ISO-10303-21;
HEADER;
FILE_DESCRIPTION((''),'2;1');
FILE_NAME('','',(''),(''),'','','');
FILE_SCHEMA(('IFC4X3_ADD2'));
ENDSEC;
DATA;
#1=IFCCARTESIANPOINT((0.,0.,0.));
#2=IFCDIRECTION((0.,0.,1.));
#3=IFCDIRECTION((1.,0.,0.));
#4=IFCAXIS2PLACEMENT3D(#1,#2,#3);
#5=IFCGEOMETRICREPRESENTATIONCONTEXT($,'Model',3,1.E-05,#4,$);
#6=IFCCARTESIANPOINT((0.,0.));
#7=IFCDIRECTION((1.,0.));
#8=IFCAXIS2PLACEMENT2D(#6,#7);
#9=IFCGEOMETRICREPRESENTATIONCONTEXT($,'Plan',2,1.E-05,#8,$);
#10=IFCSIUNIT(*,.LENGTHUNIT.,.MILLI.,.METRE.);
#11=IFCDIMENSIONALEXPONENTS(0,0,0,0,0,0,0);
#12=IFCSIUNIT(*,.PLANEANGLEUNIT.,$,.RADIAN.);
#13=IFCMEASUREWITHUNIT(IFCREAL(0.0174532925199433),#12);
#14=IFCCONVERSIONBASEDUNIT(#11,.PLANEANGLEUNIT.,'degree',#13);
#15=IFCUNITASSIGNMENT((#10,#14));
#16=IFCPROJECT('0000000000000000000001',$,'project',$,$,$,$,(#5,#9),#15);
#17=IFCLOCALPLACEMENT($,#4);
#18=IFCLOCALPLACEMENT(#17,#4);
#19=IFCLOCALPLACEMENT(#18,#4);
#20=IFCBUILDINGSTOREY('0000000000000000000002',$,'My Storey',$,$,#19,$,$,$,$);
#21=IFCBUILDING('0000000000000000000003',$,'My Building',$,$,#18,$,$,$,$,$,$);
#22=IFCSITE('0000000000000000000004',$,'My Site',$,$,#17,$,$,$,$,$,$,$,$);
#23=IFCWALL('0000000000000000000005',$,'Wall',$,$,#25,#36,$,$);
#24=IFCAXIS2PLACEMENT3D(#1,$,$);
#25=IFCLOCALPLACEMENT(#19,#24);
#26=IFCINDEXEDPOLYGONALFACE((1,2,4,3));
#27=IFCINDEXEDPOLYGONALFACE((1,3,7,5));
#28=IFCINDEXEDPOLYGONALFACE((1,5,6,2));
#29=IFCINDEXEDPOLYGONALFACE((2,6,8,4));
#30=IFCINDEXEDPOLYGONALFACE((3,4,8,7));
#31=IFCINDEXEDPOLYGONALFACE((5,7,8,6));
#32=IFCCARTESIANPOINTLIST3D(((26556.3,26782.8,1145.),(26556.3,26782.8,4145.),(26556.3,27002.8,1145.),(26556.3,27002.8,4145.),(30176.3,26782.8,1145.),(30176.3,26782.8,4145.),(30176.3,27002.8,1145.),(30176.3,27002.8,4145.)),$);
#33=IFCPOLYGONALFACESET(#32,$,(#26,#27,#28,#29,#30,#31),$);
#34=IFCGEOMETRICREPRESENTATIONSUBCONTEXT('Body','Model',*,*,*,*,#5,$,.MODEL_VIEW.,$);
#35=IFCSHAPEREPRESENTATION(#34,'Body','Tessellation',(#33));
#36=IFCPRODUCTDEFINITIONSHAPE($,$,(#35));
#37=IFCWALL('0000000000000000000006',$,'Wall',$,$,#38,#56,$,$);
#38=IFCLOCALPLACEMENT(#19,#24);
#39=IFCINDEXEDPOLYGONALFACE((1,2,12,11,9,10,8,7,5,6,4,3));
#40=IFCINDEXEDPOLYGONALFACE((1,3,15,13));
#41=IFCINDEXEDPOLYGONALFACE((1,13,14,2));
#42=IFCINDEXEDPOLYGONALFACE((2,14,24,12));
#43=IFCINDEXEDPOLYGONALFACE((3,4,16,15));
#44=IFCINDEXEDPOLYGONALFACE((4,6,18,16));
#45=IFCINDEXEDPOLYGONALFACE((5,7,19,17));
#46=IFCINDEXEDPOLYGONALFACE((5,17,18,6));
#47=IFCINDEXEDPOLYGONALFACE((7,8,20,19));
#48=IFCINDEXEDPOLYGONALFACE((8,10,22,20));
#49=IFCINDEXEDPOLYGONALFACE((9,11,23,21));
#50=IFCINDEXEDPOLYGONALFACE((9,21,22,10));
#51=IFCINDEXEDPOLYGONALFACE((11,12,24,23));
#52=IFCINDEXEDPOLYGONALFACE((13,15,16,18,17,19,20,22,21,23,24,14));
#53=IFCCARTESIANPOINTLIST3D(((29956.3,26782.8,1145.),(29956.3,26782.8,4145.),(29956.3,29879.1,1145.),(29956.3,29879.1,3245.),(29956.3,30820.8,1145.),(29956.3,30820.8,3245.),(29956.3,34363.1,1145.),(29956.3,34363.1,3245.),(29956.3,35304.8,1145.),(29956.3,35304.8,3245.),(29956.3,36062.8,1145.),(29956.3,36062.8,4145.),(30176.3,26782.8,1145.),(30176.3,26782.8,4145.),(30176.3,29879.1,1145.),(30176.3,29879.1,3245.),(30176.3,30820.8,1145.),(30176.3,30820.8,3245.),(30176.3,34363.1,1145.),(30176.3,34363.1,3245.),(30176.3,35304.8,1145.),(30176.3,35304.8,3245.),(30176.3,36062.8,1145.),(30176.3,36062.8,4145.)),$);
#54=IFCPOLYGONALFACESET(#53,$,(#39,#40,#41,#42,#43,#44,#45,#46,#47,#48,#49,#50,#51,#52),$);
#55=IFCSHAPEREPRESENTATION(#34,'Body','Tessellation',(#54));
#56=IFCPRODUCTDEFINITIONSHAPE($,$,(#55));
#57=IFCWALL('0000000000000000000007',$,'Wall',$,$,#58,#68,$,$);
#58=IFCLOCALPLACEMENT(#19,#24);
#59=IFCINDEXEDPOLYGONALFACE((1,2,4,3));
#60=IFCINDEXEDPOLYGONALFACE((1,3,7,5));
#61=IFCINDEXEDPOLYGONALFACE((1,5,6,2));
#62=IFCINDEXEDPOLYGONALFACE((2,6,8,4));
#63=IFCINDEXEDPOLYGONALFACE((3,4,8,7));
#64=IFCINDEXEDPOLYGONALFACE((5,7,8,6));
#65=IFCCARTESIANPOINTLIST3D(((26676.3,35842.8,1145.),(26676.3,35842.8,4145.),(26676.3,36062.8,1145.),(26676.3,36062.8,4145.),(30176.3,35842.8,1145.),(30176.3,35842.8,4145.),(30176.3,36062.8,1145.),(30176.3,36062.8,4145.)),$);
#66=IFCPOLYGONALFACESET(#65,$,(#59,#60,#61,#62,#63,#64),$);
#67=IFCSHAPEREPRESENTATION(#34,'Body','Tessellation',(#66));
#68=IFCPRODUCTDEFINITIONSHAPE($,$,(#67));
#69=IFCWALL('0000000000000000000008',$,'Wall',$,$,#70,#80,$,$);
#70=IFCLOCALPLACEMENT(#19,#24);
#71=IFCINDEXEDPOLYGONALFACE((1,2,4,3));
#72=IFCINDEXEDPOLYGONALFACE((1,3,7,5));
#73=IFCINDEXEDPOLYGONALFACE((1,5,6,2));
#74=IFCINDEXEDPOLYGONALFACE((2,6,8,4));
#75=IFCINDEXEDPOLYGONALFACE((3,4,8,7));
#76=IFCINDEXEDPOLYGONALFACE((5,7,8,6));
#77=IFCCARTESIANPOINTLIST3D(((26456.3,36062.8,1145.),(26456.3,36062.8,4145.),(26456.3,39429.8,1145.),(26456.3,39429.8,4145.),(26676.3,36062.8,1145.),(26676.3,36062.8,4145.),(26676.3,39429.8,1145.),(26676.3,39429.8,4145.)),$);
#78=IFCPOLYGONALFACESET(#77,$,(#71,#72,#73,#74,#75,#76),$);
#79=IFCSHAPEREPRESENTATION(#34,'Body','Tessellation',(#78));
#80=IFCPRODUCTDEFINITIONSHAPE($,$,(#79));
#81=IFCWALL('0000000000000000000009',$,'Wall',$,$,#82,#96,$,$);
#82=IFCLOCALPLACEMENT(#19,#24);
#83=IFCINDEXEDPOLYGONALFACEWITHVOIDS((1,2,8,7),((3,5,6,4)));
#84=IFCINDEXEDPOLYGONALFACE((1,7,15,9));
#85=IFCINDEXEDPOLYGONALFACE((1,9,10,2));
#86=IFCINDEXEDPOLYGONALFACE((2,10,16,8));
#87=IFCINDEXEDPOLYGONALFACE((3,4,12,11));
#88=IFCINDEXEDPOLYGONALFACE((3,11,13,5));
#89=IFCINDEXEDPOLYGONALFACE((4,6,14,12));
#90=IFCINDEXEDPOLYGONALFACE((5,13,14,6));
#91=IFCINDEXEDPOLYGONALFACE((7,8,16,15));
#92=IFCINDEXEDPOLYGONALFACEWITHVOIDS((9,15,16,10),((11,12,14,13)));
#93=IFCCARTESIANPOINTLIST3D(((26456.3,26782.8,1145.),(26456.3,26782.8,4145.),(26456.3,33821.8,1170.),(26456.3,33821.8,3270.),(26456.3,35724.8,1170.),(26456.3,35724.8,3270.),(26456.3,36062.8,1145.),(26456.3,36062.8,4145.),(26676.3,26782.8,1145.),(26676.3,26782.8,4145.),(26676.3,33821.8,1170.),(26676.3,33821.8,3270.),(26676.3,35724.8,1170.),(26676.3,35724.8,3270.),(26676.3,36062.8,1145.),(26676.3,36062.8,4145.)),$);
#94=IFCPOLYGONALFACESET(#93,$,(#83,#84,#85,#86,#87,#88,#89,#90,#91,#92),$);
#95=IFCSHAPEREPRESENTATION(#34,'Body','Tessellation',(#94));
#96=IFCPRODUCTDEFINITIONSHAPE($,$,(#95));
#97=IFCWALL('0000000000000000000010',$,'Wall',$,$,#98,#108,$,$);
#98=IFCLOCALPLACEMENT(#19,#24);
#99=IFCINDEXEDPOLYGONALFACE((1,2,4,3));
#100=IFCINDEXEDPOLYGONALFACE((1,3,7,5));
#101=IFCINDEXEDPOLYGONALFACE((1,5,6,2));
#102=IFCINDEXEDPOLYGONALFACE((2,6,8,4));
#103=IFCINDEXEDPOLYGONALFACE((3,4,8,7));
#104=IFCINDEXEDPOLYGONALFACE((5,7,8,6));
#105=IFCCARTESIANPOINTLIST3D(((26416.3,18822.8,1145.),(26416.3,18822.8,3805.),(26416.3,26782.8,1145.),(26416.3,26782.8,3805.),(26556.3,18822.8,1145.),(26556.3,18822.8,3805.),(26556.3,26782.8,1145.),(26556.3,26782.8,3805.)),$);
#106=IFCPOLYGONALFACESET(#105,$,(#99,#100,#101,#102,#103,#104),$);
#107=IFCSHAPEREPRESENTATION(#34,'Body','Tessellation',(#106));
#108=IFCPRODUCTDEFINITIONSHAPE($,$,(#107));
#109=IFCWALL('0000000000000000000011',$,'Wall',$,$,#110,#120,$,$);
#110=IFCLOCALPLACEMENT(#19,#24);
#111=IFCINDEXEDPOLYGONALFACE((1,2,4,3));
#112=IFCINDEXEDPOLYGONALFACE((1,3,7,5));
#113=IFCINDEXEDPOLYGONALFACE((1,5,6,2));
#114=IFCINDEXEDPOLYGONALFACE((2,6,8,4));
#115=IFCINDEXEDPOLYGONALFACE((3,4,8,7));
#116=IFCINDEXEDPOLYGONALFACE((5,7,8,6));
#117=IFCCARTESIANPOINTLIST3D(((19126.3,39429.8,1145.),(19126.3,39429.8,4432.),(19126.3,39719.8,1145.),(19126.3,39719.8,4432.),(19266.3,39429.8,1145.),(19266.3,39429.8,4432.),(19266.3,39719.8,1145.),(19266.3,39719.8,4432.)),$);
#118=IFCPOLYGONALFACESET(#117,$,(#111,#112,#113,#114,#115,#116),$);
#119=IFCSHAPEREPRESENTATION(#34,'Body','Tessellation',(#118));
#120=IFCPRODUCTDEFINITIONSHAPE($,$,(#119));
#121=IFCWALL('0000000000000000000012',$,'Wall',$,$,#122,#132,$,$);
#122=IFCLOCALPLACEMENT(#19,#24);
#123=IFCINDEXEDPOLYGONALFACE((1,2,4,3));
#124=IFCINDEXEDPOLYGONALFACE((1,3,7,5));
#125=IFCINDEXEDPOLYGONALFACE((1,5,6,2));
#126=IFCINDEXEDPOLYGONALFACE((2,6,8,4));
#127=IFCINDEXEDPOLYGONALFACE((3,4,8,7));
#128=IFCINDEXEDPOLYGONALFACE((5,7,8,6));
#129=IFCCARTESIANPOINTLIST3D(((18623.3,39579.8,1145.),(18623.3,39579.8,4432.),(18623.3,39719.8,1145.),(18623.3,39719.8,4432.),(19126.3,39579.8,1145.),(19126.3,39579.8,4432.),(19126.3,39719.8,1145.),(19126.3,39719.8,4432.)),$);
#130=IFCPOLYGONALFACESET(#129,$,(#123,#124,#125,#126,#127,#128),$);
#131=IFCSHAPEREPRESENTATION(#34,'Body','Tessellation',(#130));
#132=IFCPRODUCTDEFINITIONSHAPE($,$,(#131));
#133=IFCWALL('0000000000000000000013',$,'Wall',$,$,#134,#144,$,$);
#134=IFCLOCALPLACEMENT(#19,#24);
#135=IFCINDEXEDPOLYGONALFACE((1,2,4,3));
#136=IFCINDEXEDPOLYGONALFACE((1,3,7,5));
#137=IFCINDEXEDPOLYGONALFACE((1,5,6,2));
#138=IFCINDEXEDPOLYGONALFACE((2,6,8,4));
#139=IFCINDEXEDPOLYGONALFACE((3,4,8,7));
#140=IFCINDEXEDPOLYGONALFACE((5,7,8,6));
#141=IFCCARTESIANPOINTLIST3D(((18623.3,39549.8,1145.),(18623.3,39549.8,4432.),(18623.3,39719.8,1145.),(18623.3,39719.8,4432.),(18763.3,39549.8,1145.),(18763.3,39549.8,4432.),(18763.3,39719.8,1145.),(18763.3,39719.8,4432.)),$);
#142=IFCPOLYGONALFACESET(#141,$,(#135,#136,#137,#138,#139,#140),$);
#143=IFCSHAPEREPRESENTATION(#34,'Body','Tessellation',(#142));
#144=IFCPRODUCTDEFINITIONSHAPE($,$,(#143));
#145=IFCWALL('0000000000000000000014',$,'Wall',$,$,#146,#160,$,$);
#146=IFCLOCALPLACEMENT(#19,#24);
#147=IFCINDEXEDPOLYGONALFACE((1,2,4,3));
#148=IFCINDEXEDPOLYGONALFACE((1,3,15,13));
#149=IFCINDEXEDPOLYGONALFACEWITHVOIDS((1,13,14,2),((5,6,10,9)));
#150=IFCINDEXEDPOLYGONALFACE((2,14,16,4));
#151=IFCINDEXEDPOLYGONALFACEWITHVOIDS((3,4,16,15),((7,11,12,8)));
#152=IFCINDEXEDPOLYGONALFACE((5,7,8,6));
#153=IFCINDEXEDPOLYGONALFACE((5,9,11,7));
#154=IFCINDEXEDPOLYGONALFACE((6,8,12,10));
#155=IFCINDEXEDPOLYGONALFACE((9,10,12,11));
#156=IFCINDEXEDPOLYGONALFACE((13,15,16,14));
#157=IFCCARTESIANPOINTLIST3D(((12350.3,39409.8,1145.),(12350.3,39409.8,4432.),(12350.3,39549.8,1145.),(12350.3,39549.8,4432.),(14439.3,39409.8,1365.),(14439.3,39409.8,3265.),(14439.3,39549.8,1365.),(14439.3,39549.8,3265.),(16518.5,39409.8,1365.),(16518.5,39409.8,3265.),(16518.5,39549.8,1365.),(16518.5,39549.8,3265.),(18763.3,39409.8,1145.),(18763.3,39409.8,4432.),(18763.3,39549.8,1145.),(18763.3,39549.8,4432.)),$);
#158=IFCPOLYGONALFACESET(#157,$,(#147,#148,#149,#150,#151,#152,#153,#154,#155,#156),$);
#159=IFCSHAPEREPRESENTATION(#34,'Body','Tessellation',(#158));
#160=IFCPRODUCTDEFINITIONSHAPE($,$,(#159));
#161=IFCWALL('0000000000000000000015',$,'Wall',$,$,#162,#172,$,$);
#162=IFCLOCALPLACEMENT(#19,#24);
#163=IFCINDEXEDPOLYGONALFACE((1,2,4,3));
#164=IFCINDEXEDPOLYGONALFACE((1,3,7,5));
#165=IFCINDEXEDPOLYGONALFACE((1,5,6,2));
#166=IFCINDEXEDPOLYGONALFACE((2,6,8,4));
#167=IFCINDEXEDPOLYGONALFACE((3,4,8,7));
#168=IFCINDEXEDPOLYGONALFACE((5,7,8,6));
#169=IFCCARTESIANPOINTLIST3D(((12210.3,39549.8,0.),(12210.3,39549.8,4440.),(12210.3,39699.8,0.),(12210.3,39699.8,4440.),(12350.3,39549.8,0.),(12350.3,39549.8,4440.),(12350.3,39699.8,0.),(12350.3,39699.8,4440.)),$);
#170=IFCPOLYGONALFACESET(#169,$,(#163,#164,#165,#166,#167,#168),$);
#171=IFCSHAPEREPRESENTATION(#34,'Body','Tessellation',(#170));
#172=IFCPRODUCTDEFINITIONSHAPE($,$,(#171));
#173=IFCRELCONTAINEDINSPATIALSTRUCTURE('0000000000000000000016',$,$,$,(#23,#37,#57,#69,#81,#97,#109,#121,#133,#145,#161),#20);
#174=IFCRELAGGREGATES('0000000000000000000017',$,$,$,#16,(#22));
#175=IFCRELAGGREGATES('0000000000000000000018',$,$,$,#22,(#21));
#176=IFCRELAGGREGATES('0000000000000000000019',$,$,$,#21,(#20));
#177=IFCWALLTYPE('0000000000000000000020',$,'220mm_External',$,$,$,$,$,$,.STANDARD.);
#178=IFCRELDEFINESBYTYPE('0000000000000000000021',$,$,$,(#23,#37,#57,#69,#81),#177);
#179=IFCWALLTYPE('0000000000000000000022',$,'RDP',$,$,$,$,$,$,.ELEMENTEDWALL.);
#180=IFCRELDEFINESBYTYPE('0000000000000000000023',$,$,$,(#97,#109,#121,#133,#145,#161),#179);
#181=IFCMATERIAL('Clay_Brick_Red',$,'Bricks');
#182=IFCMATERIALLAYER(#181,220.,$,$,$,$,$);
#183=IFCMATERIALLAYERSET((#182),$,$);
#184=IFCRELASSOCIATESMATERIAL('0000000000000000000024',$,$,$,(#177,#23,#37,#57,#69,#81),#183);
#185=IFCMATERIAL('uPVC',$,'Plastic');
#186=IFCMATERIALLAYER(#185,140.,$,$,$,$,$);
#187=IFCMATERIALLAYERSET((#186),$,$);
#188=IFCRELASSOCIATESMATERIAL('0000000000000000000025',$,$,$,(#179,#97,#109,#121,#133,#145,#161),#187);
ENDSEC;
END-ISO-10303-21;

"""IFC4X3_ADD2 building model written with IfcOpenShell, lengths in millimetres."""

from ifc_helpers import new_model, entity, si_unit, converted_unit, frame, origin_with_axes, origin_2d_with_axis, place, context, subcontext, project, spatial, line, indexed_curve, outline, extrude, material, layer, layer_set, layer_usage, type_object, element, save


model = new_model("IFC4X3_ADD2")

# Units and contexts
model_context = context("Model", 3, precision=1e-05, world=origin_with_axes())
plan_context = context("Plan", 2, precision=1e-05, world=origin_2d_with_axis())
body_context_1 = subcontext(model_context, "Body", "Model", "MODEL_VIEW")
ifc_project = project(units=[si_unit("LENGTHUNIT", "METRE", prefix="MILLI"), converted_unit("PLANEANGLEUNIT", "degree", entity("IfcReal", 0.0174532925199433), si_unit("PLANEANGLEUNIT", "RADIAN"), dimensions=[0, 0, 0, 0, 0, 0, 0])], contexts=[model_context, plan_context])

# Site, building, storey
site_placement = place(None, origin_with_axes())
site = spatial("IfcSite", under=ifc_project, at=site_placement, Name="My Site")
building_placement = place(site_placement, origin_with_axes())
building = spatial("IfcBuilding", under=site, at=building_placement, Name="My Building")
storey_placement = place(building_placement, origin_with_axes())
storey = spatial("IfcBuildingStorey", under=building, at=storey_placement, Name="My Storey")

# Wall
ifc_material_1 = material(Name="Clay_Brick_Red", Category="Bricks")
ifc_layer_1 = layer(ifc_material_1, 220.0)
ifc_layer_set_1 = layer_set([ifc_layer_1])
ifc_layer_usage_1 = layer_usage(ifc_layer_set_1, "AXIS2", "POSITIVE", 0.0)
wall_type_1 = type_object("IfcWallType", Name="220mm_External", PredefinedType="STANDARD", material=ifc_layer_set_1)
wall_1_placement = place(storey_placement, frame((26556.3, 26782.8, 1145.0), z_axis=(0.0, 0.0, 1.0), x_axis=(1.0, 0.000001, 0.0)))
element("IfcWall", 1, at=wall_1_placement, inside=storey, type_object=wall_type_1, material=ifc_layer_usage_1, Name="Wall", context=body_context_1, shape_type="SweptSolid", body=[
    extrude(outline(indexed_curve([(0.0, 0.0), (0.0, 220.0), (3620.0, 220.0), (3620.0, 0.0)], segments=[line(1, 2, 3, 4, 1)])), origin_with_axes(), (0.0, 0.0, 1.0), 3000.0),
])

# Wall, openings
ifc_layer_usage_2 = layer_usage(ifc_layer_set_1, "AXIS2", "POSITIVE", 0.0)
wall_2_placement = place(storey_placement, frame((30176.3, 26782.8, 1145.0), z_axis=(0.0, 0.0, 1.0), x_axis=(-0.000001, 1.0, 0.0)))
wall_2 = element("IfcWall", 2, at=wall_2_placement, inside=storey, type_object=wall_type_1, material=ifc_layer_usage_2, Name="Wall", context=body_context_1, shape_type="SweptSolid", body=[
    extrude(outline(indexed_curve([(0.0, 0.0), (0.0, 220.0), (9280.0, 220.0), (9280.0, 0.0)], segments=[line(1, 2, 3, 4, 1)])), origin_with_axes(), (0.0, 0.0, 1.0), 3000.0),
])
opening_1_placement = place(wall_2_placement, frame((3096.3, 370.0, 0.0), z_axis=(0.0, 0.0, 1.0), x_axis=(-0.000001, -1.0, 0.0)))
element("IfcOpeningElement", 3, at=opening_1_placement, cuts=wall_2, PredefinedType="OPENING", context=body_context_1, shape_type="SweptSolid", body=[
    extrude(outline(indexed_curve([(0.0, 0.0), (500.0, 0.0), (500.0, 941.7), (0.0, 941.7), (0.0, 0.0)])), origin_with_axes(), (0.0, 0.0, 1.0), 2100.0),
])
opening_2_placement = place(wall_2_placement, frame((7580.3, 370.0, 0.0), z_axis=(0.0, 0.0, 1.0), x_axis=(-0.000001, -1.0, 0.0)))
element("IfcOpeningElement", 4, at=opening_2_placement, cuts=wall_2, PredefinedType="OPENING", context=body_context_1, shape_type="SweptSolid", body=[
    extrude(outline(indexed_curve([(0.0, 0.0), (500.0, 0.0), (500.0, 941.7), (0.0, 941.7), (0.0, 0.0)])), origin_with_axes(), (0.0, 0.0, 1.0), 2100.0),
])

# Walls
ifc_layer_usage_3 = layer_usage(ifc_layer_set_1, "AXIS2", "POSITIVE", 0.0)
wall_3_placement = place(storey_placement, frame((30176.3, 36062.8, 1145.0), z_axis=(0.0, 0.0, 1.0), x_axis=(-1.0, -0.000001, 0.0)))
element("IfcWall", 5, at=wall_3_placement, inside=storey, type_object=wall_type_1, material=ifc_layer_usage_3, Name="Wall", context=body_context_1, shape_type="SweptSolid", body=[
    extrude(outline(indexed_curve([(0.0, 0.0), (0.0, 220.0), (3500.0, 220.0), (3500.0, 0.0)], segments=[line(1, 2, 3, 4, 1)])), origin_with_axes(), (0.0, 0.0, 1.0), 3000.0),
])
ifc_layer_usage_4 = layer_usage(ifc_layer_set_1, "AXIS2", "POSITIVE", 0.0)
wall_4_placement = place(storey_placement, frame((26456.3, 39429.8, 1145.0), z_axis=(0.0, 0.0, 1.0), x_axis=(0.000002, -1.0, 0.0)))
element("IfcWall", 6, at=wall_4_placement, inside=storey, type_object=wall_type_1, material=ifc_layer_usage_4, Name="Wall", context=body_context_1, shape_type="SweptSolid", body=[
    extrude(outline(indexed_curve([(0.0, 0.0), (0.0, 220.0), (3367.0, 220.0), (3367.0, 0.0)], segments=[line(1, 2, 3, 4, 1)])), origin_with_axes(), (0.0, 0.0, 1.0), 3000.0),
])

# Wall, opening
ifc_layer_usage_5 = layer_usage(ifc_layer_set_1, "AXIS2", "POSITIVE", 0.0)
wall_5_placement = place(storey_placement, frame((26676.3, 26782.8, 1145.0), z_axis=(0.0, 0.0, 1.0), x_axis=(-0.000001, 1.0, 0.0)))
wall_5 = element("IfcWall", 7, at=wall_5_placement, inside=storey, type_object=wall_type_1, material=ifc_layer_usage_5, Name="Wall", context=body_context_1, shape_type="SweptSolid", body=[
    extrude(outline(indexed_curve([(0.0, 0.0), (0.0, 220.0), (9280.0, 220.0), (9280.0, 0.0)], segments=[line(1, 2, 3, 4, 1)])), origin_with_axes(), (0.0, 0.0, 1.0), 3000.0),
])
opening_3_placement = place(wall_5_placement, frame((7039.0, 335.0, 25.0), z_axis=(0.0, 0.0, 1.0), x_axis=(-0.000001, -1.0, 0.0)))
element("IfcOpeningElement", 8, at=opening_3_placement, cuts=wall_5, PredefinedType="OPENING", context=body_context_1, shape_type="SweptSolid", body=[
    extrude(outline(indexed_curve([(0.0, 0.0), (500.0, 0.0), (500.0, 1903.0), (0.0, 1903.0), (0.0, 0.0)])), origin_with_axes(), (0.0, 0.0, 1.0), 2100.0),
])

# Wall
ifc_material_2 = material(Name="uPVC", Category="Plastic")
ifc_layer_2 = layer(ifc_material_2, 140.0)
ifc_layer_set_2 = layer_set([ifc_layer_2])
ifc_layer_usage_6 = layer_usage(ifc_layer_set_2, "AXIS2", "NEGATIVE", 0.0)
wall_type_2 = type_object("IfcWallType", Name="RDP", PredefinedType="ELEMENTEDWALL", material=ifc_layer_set_2)
wall_6_placement = place(storey_placement, frame((26556.3, 26782.8, 1145.0), z_axis=(0.0, 0.0, 1.0), x_axis=(0.000002, -1.0, 0.0)))
element("IfcWall", 9, at=wall_6_placement, inside=storey, type_object=wall_type_2, material=ifc_layer_usage_6, Name="Wall", context=body_context_1, shape_type="SweptSolid", body=[
    extrude(outline(indexed_curve([(0.0, -140.0), (0.0, 0.0), (7960.0, 0.0), (7960.0, -140.0)], segments=[line(1, 2, 3, 4, 1)])), origin_with_axes(), (0.0, 0.0, 1.0), 2660.0),
])

# Walls
ifc_layer_usage_7 = layer_usage(ifc_layer_set_2, "AXIS2", "POSITIVE", 0.0)
wall_7_placement = place(storey_placement, frame((19266.3, 39429.8, 1145.0), z_axis=(0.0, 0.0, 1.0), x_axis=(-0.000001, 1.0, 0.0)))
element("IfcWall", 10, at=wall_7_placement, inside=storey, type_object=wall_type_2, material=ifc_layer_usage_7, Name="Wall", context=body_context_1, shape_type="SweptSolid", body=[
    extrude(outline(indexed_curve([(0.0, 0.0), (0.0, 140.0), (290.0, 140.0), (290.0, 0.0)], segments=[line(1, 2, 3, 4, 1)])), origin_with_axes(), (0.0, 0.0, 1.0), 3287.0),
])
ifc_layer_usage_8 = layer_usage(ifc_layer_set_2, "AXIS2", "POSITIVE", 0.0)
wall_8_placement = place(storey_placement, frame((19126.3, 39719.8, 1145.0), z_axis=(0.0, 0.0, 1.0), x_axis=(-1.0, -0.000002, 0.0)))
element("IfcWall", 11, at=wall_8_placement, inside=storey, type_object=wall_type_2, material=ifc_layer_usage_8, Name="Wall", context=body_context_1, shape_type="SweptSolid", body=[
    extrude(outline(indexed_curve([(0.0, 0.0), (0.0, 140.0), (503.0, 140.0), (503.0, 0.0)], segments=[line(1, 2, 3, 4, 1)])), origin_with_axes(), (0.0, 0.0, 1.0), 3287.0),
])
ifc_layer_usage_9 = layer_usage(ifc_layer_set_2, "AXIS2", "POSITIVE", 0.0)
wall_9_placement = place(storey_placement, frame((18763.3, 39549.8, 1145.0), z_axis=(0.0, 0.0, 1.0), x_axis=(-0.000001, 1.0, 0.0)))
element("IfcWall", 12, at=wall_9_placement, inside=storey, type_object=wall_type_2, material=ifc_layer_usage_9, Name="Wall", context=body_context_1, shape_type="SweptSolid", body=[
    extrude(outline(indexed_curve([(0.0, 0.0), (0.0, 140.0), (170.0, 140.0), (170.0, 0.0)], segments=[line(1, 2, 3, 4, 1)])), origin_with_axes(), (0.0, 0.0, 1.0), 3287.0),
])

# Wall, opening
ifc_layer_usage_10 = layer_usage(ifc_layer_set_2, "AXIS2", "POSITIVE", 0.0)
wall_10_placement = place(storey_placement, frame((18763.3, 39549.8, 1145.0), z_axis=(0.0, 0.0, 1.0), x_axis=(-1.0, -0.000002, 0.0)))
wall_10 = element("IfcWall", 13, at=wall_10_placement, inside=storey, type_object=wall_type_2, material=ifc_layer_usage_10, Name="Wall", context=body_context_1, shape_type="SweptSolid", body=[
    extrude(outline(indexed_curve([(0.0, 0.0), (0.0, 140.0), (6413.0, 140.0), (6413.0, 0.0)], segments=[line(1, 2, 3, 4, 1)])), origin_with_axes(), (0.0, 0.0, 1.0), 3287.0),
])
opening_4_placement = place(wall_10_placement, frame((4324.0, 250.0, 220.0), z_axis=(0.0, 0.0, 1.0), x_axis=(-1.0, 0.000002, 0.0)))
element("IfcOpeningElement", 14, at=opening_4_placement, cuts=wall_10, PredefinedType="OPENING", context=body_context_1, shape_type="SweptSolid", body=[
    extrude(outline(indexed_curve([(0.0, 0.0), (2079.2, 0.0), (2079.2, 500.0), (0.0, 500.0), (0.0, 0.0)])), origin_with_axes(), (0.0, 0.0, 1.0), 1900.0),
])

# Wall
ifc_layer_usage_11 = layer_usage(ifc_layer_set_2, "AXIS2", "POSITIVE", 0.0)
wall_11_placement = place(storey_placement, frame((12210.3, 39699.8, 0.0), z_axis=(0.0, 0.0, 1.0), x_axis=(0.000002, -1.0, 0.0)))
element("IfcWall", 15, at=wall_11_placement, inside=storey, type_object=wall_type_2, material=ifc_layer_usage_11, Name="Wall", context=body_context_1, shape_type="SweptSolid", body=[
    extrude(outline(indexed_curve([(0.0, 0.0), (0.0, 140.0), (150.0, 140.0), (150.0, 0.0)], segments=[line(1, 2, 3, 4, 1)])), origin_with_axes(), (0.0, 0.0, 1.0), 4440.0),
])

save(model, "model.ifc")
